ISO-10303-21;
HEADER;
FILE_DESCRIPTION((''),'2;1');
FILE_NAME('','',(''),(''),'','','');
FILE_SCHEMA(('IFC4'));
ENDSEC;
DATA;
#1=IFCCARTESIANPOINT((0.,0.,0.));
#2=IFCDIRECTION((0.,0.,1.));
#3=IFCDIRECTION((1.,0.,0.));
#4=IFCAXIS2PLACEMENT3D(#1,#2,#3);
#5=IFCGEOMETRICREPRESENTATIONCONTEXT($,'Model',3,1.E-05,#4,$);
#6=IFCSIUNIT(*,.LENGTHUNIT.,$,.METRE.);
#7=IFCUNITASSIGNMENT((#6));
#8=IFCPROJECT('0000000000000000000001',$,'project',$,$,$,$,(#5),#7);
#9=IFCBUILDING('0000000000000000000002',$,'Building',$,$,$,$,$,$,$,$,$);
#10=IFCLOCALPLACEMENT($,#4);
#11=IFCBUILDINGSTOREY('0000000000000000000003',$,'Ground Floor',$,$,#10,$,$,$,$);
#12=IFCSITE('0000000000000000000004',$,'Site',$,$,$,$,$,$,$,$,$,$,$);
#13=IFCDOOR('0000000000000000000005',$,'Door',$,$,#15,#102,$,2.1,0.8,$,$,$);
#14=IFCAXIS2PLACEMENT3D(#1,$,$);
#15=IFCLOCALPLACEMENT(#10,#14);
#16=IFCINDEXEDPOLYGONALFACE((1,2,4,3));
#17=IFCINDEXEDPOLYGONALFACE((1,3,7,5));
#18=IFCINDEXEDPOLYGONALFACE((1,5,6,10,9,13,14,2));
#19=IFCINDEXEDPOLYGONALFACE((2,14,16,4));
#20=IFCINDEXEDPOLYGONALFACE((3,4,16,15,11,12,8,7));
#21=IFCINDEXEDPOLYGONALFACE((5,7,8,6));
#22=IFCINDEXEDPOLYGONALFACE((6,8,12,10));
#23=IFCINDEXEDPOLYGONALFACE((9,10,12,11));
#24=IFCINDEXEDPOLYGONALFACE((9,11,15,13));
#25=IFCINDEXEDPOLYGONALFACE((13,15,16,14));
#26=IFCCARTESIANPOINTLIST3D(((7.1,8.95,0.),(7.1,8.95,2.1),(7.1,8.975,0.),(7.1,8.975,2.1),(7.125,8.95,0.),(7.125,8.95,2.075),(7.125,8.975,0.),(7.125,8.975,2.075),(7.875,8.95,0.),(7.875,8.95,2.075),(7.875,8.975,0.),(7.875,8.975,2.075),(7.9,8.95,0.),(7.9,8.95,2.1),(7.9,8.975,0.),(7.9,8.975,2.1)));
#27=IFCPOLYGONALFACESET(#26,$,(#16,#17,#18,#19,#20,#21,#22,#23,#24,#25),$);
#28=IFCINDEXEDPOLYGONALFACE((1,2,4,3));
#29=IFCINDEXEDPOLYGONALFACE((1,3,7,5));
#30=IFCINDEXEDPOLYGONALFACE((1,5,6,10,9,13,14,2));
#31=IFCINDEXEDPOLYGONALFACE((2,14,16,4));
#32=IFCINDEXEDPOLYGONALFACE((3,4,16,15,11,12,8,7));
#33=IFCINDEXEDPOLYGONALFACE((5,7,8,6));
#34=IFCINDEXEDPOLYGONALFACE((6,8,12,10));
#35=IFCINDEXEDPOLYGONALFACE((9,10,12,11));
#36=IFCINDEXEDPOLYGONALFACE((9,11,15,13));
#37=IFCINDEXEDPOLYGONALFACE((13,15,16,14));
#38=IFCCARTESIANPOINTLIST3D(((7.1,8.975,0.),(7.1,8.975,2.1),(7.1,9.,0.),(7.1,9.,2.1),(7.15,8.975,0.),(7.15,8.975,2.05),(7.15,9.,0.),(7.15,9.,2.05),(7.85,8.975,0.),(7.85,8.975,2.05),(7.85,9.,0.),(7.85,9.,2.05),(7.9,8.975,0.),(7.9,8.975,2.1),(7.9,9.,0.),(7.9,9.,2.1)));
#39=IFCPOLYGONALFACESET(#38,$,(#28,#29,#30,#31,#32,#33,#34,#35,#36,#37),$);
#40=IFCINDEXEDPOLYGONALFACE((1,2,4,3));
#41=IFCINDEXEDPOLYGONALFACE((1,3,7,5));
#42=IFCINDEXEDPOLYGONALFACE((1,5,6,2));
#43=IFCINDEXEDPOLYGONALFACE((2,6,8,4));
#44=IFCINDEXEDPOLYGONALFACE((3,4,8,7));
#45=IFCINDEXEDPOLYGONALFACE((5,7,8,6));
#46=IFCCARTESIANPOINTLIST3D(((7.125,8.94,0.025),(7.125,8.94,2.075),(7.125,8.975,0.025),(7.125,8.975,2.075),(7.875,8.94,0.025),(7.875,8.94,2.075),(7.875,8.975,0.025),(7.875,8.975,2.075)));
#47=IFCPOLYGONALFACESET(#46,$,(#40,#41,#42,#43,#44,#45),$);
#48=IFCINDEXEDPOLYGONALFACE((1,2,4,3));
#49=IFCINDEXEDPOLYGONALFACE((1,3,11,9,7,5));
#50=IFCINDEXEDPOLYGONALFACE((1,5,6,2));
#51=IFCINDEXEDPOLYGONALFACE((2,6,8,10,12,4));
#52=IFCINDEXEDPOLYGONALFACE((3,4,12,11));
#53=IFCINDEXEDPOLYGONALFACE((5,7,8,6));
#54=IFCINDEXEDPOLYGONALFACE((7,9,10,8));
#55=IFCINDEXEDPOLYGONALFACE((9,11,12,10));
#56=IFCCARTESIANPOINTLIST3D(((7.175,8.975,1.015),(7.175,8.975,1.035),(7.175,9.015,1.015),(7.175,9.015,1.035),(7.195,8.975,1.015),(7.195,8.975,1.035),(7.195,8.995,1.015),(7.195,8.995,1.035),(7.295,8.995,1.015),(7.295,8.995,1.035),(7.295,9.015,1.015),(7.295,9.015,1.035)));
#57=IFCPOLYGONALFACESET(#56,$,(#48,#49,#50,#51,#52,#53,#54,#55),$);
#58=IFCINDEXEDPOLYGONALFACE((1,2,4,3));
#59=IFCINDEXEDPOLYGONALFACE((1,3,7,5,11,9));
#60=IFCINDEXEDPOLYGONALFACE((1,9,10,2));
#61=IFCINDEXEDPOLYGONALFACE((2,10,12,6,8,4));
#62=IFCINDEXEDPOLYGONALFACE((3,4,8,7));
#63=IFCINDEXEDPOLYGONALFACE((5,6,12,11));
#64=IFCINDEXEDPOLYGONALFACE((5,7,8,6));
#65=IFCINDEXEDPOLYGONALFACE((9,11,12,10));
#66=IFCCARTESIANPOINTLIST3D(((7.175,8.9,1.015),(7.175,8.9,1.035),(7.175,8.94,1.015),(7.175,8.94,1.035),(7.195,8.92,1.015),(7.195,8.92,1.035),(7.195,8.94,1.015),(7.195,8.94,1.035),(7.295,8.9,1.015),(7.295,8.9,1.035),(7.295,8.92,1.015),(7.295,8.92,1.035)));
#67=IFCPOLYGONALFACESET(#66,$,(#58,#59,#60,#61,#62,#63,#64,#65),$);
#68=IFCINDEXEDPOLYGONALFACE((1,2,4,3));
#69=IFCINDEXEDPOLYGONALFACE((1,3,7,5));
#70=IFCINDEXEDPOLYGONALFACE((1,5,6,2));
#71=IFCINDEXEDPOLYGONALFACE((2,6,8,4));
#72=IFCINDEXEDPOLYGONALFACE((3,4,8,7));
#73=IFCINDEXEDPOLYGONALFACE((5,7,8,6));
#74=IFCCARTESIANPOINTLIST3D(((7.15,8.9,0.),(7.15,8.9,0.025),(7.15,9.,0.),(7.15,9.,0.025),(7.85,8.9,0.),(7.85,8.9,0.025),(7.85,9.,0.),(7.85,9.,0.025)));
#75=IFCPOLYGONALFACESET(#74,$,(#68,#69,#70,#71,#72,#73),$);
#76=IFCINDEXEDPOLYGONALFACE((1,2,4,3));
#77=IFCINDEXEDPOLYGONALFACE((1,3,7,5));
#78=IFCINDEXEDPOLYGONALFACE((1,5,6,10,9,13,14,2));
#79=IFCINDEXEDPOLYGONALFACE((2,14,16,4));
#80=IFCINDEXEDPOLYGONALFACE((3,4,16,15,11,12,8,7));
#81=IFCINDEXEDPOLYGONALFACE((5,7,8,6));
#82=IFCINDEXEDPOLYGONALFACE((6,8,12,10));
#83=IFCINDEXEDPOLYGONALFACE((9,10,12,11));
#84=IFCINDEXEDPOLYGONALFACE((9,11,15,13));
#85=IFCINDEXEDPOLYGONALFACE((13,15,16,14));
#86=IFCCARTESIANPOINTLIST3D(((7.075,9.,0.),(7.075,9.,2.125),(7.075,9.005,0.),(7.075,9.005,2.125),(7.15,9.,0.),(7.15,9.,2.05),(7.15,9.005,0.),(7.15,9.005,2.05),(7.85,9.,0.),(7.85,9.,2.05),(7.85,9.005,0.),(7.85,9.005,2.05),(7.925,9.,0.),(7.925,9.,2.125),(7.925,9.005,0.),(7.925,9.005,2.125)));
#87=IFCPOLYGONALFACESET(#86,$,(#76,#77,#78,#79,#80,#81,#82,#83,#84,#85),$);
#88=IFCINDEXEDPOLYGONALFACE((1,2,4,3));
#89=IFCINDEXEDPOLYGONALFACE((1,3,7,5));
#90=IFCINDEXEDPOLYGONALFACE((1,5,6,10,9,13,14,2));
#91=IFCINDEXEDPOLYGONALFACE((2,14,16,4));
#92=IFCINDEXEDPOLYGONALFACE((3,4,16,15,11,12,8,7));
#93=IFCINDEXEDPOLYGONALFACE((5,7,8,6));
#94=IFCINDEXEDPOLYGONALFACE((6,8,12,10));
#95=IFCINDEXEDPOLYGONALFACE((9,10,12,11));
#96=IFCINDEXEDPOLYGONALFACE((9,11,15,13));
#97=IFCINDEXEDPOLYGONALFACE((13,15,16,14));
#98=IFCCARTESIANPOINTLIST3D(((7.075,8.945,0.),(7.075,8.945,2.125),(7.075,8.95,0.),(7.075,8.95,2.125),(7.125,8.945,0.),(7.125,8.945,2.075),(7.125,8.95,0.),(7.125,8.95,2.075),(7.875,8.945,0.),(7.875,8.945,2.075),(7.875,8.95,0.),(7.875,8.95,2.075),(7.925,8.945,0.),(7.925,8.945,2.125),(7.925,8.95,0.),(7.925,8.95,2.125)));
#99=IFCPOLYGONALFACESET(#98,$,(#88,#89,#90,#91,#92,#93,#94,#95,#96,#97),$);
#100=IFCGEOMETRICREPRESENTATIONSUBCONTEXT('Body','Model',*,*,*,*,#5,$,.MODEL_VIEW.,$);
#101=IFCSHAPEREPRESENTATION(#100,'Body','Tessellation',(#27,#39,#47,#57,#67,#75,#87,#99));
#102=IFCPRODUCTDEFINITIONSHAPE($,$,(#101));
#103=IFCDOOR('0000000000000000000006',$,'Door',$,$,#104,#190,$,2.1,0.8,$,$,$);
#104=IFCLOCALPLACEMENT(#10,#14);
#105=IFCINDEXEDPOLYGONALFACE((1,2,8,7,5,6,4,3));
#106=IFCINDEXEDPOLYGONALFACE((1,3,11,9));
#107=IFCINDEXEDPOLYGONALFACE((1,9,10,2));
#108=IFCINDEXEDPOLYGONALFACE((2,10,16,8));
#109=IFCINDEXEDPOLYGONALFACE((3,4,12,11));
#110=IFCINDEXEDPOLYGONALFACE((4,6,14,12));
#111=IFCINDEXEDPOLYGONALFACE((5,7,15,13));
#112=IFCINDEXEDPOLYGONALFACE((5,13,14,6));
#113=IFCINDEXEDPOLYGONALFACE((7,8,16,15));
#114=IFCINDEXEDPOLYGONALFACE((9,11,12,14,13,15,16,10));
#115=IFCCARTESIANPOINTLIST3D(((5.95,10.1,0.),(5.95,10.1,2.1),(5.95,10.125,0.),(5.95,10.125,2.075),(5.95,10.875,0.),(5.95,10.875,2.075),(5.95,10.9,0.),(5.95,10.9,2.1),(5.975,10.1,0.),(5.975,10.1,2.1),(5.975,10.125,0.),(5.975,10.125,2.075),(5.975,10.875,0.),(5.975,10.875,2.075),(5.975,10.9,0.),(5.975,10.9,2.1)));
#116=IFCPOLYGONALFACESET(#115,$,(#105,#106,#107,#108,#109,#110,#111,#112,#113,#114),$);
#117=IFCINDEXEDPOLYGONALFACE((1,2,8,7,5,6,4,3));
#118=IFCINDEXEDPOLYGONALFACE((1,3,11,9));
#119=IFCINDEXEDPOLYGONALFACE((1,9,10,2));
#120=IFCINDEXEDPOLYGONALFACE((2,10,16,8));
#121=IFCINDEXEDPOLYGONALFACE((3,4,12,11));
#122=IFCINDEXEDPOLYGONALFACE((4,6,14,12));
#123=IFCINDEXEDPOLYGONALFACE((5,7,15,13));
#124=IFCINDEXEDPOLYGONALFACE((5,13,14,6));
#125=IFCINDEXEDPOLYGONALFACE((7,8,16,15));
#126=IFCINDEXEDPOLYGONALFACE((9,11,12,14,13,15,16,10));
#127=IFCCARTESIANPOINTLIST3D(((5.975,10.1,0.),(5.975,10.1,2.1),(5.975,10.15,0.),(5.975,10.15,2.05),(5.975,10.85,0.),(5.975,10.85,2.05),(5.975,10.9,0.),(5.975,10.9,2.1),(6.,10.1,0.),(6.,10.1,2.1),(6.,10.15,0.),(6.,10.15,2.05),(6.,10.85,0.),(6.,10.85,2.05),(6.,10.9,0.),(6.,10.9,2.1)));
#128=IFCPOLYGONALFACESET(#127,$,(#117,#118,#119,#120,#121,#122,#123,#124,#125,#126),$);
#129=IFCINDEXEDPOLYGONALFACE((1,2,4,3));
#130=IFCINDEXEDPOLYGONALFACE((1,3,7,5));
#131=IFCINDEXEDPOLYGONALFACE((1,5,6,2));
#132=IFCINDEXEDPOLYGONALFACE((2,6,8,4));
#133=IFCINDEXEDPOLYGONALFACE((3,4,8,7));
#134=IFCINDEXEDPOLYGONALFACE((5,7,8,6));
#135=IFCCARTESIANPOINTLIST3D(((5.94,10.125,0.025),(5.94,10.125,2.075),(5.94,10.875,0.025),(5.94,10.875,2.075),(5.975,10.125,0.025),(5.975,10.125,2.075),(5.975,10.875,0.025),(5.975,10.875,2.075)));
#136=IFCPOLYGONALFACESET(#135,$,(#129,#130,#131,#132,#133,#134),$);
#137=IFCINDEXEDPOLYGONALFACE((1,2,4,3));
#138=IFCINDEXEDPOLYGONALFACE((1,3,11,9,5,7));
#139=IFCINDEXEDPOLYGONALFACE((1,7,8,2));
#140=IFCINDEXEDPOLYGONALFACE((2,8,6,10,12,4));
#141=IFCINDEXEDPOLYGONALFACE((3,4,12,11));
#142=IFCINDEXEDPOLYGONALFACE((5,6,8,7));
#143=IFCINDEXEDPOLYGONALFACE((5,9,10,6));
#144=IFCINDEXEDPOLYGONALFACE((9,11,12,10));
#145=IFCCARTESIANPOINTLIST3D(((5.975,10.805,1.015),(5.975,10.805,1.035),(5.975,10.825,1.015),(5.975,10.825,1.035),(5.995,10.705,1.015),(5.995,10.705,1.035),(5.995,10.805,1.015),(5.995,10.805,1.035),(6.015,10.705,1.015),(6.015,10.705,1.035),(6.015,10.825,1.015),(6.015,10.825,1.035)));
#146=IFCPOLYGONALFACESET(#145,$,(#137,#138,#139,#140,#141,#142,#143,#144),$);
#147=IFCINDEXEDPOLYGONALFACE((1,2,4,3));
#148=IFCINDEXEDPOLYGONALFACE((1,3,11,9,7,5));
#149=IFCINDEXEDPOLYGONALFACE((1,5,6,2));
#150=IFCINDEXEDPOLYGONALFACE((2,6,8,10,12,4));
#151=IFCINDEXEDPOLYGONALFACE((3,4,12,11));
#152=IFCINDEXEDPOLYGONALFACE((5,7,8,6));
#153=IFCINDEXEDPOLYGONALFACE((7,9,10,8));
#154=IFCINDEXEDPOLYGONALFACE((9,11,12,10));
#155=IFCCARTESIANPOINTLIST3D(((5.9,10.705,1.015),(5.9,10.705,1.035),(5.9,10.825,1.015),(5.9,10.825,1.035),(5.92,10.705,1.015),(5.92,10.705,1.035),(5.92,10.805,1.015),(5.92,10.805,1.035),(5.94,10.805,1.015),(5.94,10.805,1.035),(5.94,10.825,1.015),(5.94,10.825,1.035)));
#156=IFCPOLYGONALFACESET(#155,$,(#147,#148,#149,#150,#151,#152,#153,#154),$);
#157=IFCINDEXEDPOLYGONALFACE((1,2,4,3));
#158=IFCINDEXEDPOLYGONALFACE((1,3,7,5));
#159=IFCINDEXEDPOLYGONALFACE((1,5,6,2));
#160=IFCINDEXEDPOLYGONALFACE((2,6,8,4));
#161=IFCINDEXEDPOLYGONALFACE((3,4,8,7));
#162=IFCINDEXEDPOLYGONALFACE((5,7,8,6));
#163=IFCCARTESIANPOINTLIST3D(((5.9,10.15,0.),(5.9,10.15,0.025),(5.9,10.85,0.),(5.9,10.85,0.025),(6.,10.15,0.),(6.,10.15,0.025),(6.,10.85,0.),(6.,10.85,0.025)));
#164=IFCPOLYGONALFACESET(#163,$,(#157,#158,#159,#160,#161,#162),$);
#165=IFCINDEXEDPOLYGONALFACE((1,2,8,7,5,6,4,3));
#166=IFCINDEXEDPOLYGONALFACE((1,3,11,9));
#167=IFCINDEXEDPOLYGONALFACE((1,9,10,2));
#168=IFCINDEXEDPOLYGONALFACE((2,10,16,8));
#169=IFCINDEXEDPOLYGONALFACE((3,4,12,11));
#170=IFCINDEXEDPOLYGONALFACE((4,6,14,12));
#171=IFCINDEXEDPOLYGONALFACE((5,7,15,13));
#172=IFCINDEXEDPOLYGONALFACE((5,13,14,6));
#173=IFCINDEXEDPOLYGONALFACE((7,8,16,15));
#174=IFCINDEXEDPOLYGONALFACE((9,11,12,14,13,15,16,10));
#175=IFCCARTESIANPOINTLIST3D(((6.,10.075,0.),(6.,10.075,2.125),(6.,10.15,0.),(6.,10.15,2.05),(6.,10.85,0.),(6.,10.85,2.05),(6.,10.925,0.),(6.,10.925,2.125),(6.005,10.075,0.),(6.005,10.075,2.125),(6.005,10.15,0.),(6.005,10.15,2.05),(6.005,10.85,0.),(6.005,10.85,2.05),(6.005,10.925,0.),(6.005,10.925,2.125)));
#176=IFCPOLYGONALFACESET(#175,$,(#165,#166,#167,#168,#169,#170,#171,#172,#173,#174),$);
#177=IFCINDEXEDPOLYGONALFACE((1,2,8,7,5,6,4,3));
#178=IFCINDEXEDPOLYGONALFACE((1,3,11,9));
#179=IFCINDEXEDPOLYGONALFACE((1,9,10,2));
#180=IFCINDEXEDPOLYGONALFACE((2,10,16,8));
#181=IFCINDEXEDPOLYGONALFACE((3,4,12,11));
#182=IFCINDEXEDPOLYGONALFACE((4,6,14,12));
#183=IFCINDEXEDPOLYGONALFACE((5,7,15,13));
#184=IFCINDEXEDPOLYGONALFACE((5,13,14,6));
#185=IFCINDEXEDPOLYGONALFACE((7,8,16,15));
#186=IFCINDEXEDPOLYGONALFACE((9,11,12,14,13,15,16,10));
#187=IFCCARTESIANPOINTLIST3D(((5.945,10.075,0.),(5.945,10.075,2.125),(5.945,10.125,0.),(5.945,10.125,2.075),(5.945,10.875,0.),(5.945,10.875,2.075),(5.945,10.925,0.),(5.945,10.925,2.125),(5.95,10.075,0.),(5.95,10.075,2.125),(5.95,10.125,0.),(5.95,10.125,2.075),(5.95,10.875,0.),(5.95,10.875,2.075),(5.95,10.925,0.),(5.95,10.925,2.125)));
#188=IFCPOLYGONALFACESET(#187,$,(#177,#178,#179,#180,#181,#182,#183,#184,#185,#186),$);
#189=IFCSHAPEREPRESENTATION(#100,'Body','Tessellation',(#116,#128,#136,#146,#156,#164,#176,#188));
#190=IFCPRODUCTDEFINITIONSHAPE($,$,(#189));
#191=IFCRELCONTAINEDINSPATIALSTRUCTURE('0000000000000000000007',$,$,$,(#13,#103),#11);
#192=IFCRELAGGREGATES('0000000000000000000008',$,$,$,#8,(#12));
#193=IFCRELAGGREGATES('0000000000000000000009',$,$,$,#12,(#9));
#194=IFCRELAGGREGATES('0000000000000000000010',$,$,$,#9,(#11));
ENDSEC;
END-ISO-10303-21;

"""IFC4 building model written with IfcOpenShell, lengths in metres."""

from ifc_helpers import new_model, si_unit, frame, origin_with_axes, place, context, subcontext, project, spatial, line, indexed_curve, outline, extrude, element, save


model = new_model("IFC4")

# Units and contexts
model_context = context("Model", 3, precision=1e-05, world=origin_with_axes())
body_context = subcontext(model_context, "Body", "Model", "MODEL_VIEW")
ifc_project = project(units=[si_unit("LENGTHUNIT", "METRE")], contexts=[model_context])

# Site, building, storey
site = spatial("IfcSite", under=ifc_project, Name="Site")
building = spatial("IfcBuilding", under=site, Name="Building")
storey_placement = place(None, origin_with_axes())
storey = spatial("IfcBuildingStorey", under=building, at=storey_placement, Name="Ground Floor")

# Doors
door_1_placement = place(storey_placement, frame((7.9, 9.0, 0.0), z_axis=(0.0, 0.0, 1.0), x_axis=(-1.0, 0.0, 0.0)))
element("IfcDoor", 1, at=door_1_placement, inside=storey, Name="Door", OverallHeight=2.1, OverallWidth=0.8, context=body_context, shape_type="SweptSolid", body=[
    extrude(outline(indexed_curve([(0.0, 0.0), (0.0, 2.1), (0.8, 2.1), (0.8, 0.0), (0.775, 0.0), (0.775, 2.075), (0.025, 2.075), (0.025, 0.0)], segments=[line(1, 2, 3, 4, 5, 6, 7, 8, 1)])), frame((0.0, 0.025, 0.0), z_axis=(0.0, -1.0, 0.0), x_axis=(1.0, 0.0, 0.0)), (0.0, 0.0, -1.0), 0.025),
    extrude(outline(indexed_curve([(0.0, 0.0), (0.0, 2.1), (0.8, 2.1), (0.8, 0.0), (0.75, 0.0), (0.75, 2.05), (0.05, 2.05), (0.05, 0.0)], segments=[line(1, 2, 3, 4, 5, 6, 7, 8, 1)])), frame((0.0, 0.0, 0.0), z_axis=(0.0, -1.0, 0.0), x_axis=(1.0, 0.0, 0.0)), (0.0, 0.0, -1.0), 0.025),
    extrude(outline(indexed_curve([(0.0, 0.0), (0.75, 0.0), (0.75, 0.035), (0.0, 0.035)], segments=[line(1, 2, 3, 4, 1)])), frame((0.025, 0.025, 0.025), z_axis=(0.0, 0.0, 1.0), x_axis=(1.0, 0.0, 0.0)), (0.0, 0.0, 1.0), 2.05),
    extrude(outline(indexed_curve([(0.0, 0.0), (0.0, -0.04), (-0.12, -0.04), (-0.12, -0.02), (-0.02, -0.02), (-0.02, 0.0)], segments=[line(1, 2, 3, 4, 5, 6, 1)])), frame((0.725, 0.025, 1.015), z_axis=(0.0, 0.0, 1.0), x_axis=(1.0, 0.0, 0.0)), (0.0, 0.0, 1.0), 0.02),
    extrude(outline(indexed_curve([(0.0, 0.0), (0.0, 0.04), (-0.12, 0.04), (-0.12, 0.02), (-0.02, 0.02), (-0.02, 0.0)], segments=[line(1, 2, 3, 4, 5, 6, 1)])), frame((0.725, 0.06, 1.015), z_axis=(0.0, 0.0, 1.0), x_axis=(1.0, 0.0, 0.0)), (0.0, 0.0, 1.0), 0.02),
    extrude(outline(indexed_curve([(0.0, 0.0), (0.7, 0.0), (0.7, 0.1), (0.0, 0.1)], segments=[line(1, 2, 3, 4, 1)])), frame((0.05, 0.0, 0.0), z_axis=(0.0, 0.0, 1.0), x_axis=(1.0, 0.0, 0.0)), (0.0, 0.0, 1.0), 0.025),
    extrude(outline(indexed_curve([(0.0, 0.0), (0.0, 2.125), (0.85, 2.125), (0.85, 0.0), (0.775, 0.0), (0.775, 2.05), (0.075, 2.05), (0.075, 0.0)], segments=[line(1, 2, 3, 4, 5, 6, 7, 8, 1)])), frame((-0.025, -0.005, 0.0), z_axis=(0.0, -1.0, 0.0), x_axis=(1.0, 0.0, 0.0)), (0.0, 0.0, -1.0), 0.005),
    extrude(outline(indexed_curve([(0.0, 0.0), (0.0, 2.125), (0.85, 2.125), (0.85, 0.0), (0.8, 0.0), (0.8, 2.075), (0.05, 2.075), (0.05, 0.0)], segments=[line(1, 2, 3, 4, 5, 6, 7, 8, 1)])), frame((-0.025, 0.05, 0.0), z_axis=(0.0, -1.0, 0.0), x_axis=(1.0, 0.0, 0.0)), (0.0, 0.0, -1.0), 0.005),
])
door_2_placement = place(storey_placement, frame((6.0, 10.1, 0.0), z_axis=(0.0, 0.0, 1.0), x_axis=(0.0, 1.0, 0.0)))
element("IfcDoor", 2, at=door_2_placement, inside=storey, Name="Door", OverallHeight=2.1, OverallWidth=0.8, context=body_context, shape_type="SweptSolid", body=[
    extrude(outline(indexed_curve([(0.0, 0.0), (0.0, 2.1), (0.8, 2.1), (0.8, 0.0), (0.775, 0.0), (0.775, 2.075), (0.025, 2.075), (0.025, 0.0)], segments=[line(1, 2, 3, 4, 5, 6, 7, 8, 1)])), frame((0.0, 0.025, 0.0), z_axis=(0.0, -1.0, 0.0), x_axis=(1.0, 0.0, 0.0)), (0.0, 0.0, -1.0), 0.025),
    extrude(outline(indexed_curve([(0.0, 0.0), (0.0, 2.1), (0.8, 2.1), (0.8, 0.0), (0.75, 0.0), (0.75, 2.05), (0.05, 2.05), (0.05, 0.0)], segments=[line(1, 2, 3, 4, 5, 6, 7, 8, 1)])), frame((0.0, 0.0, 0.0), z_axis=(0.0, -1.0, 0.0), x_axis=(1.0, 0.0, 0.0)), (0.0, 0.0, -1.0), 0.025),
    extrude(outline(indexed_curve([(0.0, 0.0), (0.75, 0.0), (0.75, 0.035), (0.0, 0.035)], segments=[line(1, 2, 3, 4, 1)])), frame((0.025, 0.025, 0.025), z_axis=(0.0, 0.0, 1.0), x_axis=(1.0, 0.0, 0.0)), (0.0, 0.0, 1.0), 2.05),
    extrude(outline(indexed_curve([(0.0, 0.0), (0.0, -0.04), (-0.12, -0.04), (-0.12, -0.02), (-0.02, -0.02), (-0.02, 0.0)], segments=[line(1, 2, 3, 4, 5, 6, 1)])), frame((0.725, 0.025, 1.015), z_axis=(0.0, 0.0, 1.0), x_axis=(1.0, 0.0, 0.0)), (0.0, 0.0, 1.0), 0.02),
    extrude(outline(indexed_curve([(0.0, 0.0), (0.0, 0.04), (-0.12, 0.04), (-0.12, 0.02), (-0.02, 0.02), (-0.02, 0.0)], segments=[line(1, 2, 3, 4, 5, 6, 1)])), frame((0.725, 0.06, 1.015), z_axis=(0.0, 0.0, 1.0), x_axis=(1.0, 0.0, 0.0)), (0.0, 0.0, 1.0), 0.02),
    extrude(outline(indexed_curve([(0.0, 0.0), (0.7, 0.0), (0.7, 0.1), (0.0, 0.1)], segments=[line(1, 2, 3, 4, 1)])), frame((0.05, 0.0, 0.0), z_axis=(0.0, 0.0, 1.0), x_axis=(1.0, 0.0, 0.0)), (0.0, 0.0, 1.0), 0.025),
    extrude(outline(indexed_curve([(0.0, 0.0), (0.0, 2.125), (0.85, 2.125), (0.85, 0.0), (0.775, 0.0), (0.775, 2.05), (0.075, 2.05), (0.075, 0.0)], segments=[line(1, 2, 3, 4, 5, 6, 7, 8, 1)])), frame((-0.025, -0.005, 0.0), z_axis=(0.0, -1.0, 0.0), x_axis=(1.0, 0.0, 0.0)), (0.0, 0.0, -1.0), 0.005),
    extrude(outline(indexed_curve([(0.0, 0.0), (0.0, 2.125), (0.85, 2.125), (0.85, 0.0), (0.8, 0.0), (0.8, 2.075), (0.05, 2.075), (0.05, 0.0)], segments=[line(1, 2, 3, 4, 5, 6, 7, 8, 1)])), frame((-0.025, 0.05, 0.0), z_axis=(0.0, -1.0, 0.0), x_axis=(1.0, 0.0, 0.0)), (0.0, 0.0, -1.0), 0.005),
])

save(model, "model.ifc")
